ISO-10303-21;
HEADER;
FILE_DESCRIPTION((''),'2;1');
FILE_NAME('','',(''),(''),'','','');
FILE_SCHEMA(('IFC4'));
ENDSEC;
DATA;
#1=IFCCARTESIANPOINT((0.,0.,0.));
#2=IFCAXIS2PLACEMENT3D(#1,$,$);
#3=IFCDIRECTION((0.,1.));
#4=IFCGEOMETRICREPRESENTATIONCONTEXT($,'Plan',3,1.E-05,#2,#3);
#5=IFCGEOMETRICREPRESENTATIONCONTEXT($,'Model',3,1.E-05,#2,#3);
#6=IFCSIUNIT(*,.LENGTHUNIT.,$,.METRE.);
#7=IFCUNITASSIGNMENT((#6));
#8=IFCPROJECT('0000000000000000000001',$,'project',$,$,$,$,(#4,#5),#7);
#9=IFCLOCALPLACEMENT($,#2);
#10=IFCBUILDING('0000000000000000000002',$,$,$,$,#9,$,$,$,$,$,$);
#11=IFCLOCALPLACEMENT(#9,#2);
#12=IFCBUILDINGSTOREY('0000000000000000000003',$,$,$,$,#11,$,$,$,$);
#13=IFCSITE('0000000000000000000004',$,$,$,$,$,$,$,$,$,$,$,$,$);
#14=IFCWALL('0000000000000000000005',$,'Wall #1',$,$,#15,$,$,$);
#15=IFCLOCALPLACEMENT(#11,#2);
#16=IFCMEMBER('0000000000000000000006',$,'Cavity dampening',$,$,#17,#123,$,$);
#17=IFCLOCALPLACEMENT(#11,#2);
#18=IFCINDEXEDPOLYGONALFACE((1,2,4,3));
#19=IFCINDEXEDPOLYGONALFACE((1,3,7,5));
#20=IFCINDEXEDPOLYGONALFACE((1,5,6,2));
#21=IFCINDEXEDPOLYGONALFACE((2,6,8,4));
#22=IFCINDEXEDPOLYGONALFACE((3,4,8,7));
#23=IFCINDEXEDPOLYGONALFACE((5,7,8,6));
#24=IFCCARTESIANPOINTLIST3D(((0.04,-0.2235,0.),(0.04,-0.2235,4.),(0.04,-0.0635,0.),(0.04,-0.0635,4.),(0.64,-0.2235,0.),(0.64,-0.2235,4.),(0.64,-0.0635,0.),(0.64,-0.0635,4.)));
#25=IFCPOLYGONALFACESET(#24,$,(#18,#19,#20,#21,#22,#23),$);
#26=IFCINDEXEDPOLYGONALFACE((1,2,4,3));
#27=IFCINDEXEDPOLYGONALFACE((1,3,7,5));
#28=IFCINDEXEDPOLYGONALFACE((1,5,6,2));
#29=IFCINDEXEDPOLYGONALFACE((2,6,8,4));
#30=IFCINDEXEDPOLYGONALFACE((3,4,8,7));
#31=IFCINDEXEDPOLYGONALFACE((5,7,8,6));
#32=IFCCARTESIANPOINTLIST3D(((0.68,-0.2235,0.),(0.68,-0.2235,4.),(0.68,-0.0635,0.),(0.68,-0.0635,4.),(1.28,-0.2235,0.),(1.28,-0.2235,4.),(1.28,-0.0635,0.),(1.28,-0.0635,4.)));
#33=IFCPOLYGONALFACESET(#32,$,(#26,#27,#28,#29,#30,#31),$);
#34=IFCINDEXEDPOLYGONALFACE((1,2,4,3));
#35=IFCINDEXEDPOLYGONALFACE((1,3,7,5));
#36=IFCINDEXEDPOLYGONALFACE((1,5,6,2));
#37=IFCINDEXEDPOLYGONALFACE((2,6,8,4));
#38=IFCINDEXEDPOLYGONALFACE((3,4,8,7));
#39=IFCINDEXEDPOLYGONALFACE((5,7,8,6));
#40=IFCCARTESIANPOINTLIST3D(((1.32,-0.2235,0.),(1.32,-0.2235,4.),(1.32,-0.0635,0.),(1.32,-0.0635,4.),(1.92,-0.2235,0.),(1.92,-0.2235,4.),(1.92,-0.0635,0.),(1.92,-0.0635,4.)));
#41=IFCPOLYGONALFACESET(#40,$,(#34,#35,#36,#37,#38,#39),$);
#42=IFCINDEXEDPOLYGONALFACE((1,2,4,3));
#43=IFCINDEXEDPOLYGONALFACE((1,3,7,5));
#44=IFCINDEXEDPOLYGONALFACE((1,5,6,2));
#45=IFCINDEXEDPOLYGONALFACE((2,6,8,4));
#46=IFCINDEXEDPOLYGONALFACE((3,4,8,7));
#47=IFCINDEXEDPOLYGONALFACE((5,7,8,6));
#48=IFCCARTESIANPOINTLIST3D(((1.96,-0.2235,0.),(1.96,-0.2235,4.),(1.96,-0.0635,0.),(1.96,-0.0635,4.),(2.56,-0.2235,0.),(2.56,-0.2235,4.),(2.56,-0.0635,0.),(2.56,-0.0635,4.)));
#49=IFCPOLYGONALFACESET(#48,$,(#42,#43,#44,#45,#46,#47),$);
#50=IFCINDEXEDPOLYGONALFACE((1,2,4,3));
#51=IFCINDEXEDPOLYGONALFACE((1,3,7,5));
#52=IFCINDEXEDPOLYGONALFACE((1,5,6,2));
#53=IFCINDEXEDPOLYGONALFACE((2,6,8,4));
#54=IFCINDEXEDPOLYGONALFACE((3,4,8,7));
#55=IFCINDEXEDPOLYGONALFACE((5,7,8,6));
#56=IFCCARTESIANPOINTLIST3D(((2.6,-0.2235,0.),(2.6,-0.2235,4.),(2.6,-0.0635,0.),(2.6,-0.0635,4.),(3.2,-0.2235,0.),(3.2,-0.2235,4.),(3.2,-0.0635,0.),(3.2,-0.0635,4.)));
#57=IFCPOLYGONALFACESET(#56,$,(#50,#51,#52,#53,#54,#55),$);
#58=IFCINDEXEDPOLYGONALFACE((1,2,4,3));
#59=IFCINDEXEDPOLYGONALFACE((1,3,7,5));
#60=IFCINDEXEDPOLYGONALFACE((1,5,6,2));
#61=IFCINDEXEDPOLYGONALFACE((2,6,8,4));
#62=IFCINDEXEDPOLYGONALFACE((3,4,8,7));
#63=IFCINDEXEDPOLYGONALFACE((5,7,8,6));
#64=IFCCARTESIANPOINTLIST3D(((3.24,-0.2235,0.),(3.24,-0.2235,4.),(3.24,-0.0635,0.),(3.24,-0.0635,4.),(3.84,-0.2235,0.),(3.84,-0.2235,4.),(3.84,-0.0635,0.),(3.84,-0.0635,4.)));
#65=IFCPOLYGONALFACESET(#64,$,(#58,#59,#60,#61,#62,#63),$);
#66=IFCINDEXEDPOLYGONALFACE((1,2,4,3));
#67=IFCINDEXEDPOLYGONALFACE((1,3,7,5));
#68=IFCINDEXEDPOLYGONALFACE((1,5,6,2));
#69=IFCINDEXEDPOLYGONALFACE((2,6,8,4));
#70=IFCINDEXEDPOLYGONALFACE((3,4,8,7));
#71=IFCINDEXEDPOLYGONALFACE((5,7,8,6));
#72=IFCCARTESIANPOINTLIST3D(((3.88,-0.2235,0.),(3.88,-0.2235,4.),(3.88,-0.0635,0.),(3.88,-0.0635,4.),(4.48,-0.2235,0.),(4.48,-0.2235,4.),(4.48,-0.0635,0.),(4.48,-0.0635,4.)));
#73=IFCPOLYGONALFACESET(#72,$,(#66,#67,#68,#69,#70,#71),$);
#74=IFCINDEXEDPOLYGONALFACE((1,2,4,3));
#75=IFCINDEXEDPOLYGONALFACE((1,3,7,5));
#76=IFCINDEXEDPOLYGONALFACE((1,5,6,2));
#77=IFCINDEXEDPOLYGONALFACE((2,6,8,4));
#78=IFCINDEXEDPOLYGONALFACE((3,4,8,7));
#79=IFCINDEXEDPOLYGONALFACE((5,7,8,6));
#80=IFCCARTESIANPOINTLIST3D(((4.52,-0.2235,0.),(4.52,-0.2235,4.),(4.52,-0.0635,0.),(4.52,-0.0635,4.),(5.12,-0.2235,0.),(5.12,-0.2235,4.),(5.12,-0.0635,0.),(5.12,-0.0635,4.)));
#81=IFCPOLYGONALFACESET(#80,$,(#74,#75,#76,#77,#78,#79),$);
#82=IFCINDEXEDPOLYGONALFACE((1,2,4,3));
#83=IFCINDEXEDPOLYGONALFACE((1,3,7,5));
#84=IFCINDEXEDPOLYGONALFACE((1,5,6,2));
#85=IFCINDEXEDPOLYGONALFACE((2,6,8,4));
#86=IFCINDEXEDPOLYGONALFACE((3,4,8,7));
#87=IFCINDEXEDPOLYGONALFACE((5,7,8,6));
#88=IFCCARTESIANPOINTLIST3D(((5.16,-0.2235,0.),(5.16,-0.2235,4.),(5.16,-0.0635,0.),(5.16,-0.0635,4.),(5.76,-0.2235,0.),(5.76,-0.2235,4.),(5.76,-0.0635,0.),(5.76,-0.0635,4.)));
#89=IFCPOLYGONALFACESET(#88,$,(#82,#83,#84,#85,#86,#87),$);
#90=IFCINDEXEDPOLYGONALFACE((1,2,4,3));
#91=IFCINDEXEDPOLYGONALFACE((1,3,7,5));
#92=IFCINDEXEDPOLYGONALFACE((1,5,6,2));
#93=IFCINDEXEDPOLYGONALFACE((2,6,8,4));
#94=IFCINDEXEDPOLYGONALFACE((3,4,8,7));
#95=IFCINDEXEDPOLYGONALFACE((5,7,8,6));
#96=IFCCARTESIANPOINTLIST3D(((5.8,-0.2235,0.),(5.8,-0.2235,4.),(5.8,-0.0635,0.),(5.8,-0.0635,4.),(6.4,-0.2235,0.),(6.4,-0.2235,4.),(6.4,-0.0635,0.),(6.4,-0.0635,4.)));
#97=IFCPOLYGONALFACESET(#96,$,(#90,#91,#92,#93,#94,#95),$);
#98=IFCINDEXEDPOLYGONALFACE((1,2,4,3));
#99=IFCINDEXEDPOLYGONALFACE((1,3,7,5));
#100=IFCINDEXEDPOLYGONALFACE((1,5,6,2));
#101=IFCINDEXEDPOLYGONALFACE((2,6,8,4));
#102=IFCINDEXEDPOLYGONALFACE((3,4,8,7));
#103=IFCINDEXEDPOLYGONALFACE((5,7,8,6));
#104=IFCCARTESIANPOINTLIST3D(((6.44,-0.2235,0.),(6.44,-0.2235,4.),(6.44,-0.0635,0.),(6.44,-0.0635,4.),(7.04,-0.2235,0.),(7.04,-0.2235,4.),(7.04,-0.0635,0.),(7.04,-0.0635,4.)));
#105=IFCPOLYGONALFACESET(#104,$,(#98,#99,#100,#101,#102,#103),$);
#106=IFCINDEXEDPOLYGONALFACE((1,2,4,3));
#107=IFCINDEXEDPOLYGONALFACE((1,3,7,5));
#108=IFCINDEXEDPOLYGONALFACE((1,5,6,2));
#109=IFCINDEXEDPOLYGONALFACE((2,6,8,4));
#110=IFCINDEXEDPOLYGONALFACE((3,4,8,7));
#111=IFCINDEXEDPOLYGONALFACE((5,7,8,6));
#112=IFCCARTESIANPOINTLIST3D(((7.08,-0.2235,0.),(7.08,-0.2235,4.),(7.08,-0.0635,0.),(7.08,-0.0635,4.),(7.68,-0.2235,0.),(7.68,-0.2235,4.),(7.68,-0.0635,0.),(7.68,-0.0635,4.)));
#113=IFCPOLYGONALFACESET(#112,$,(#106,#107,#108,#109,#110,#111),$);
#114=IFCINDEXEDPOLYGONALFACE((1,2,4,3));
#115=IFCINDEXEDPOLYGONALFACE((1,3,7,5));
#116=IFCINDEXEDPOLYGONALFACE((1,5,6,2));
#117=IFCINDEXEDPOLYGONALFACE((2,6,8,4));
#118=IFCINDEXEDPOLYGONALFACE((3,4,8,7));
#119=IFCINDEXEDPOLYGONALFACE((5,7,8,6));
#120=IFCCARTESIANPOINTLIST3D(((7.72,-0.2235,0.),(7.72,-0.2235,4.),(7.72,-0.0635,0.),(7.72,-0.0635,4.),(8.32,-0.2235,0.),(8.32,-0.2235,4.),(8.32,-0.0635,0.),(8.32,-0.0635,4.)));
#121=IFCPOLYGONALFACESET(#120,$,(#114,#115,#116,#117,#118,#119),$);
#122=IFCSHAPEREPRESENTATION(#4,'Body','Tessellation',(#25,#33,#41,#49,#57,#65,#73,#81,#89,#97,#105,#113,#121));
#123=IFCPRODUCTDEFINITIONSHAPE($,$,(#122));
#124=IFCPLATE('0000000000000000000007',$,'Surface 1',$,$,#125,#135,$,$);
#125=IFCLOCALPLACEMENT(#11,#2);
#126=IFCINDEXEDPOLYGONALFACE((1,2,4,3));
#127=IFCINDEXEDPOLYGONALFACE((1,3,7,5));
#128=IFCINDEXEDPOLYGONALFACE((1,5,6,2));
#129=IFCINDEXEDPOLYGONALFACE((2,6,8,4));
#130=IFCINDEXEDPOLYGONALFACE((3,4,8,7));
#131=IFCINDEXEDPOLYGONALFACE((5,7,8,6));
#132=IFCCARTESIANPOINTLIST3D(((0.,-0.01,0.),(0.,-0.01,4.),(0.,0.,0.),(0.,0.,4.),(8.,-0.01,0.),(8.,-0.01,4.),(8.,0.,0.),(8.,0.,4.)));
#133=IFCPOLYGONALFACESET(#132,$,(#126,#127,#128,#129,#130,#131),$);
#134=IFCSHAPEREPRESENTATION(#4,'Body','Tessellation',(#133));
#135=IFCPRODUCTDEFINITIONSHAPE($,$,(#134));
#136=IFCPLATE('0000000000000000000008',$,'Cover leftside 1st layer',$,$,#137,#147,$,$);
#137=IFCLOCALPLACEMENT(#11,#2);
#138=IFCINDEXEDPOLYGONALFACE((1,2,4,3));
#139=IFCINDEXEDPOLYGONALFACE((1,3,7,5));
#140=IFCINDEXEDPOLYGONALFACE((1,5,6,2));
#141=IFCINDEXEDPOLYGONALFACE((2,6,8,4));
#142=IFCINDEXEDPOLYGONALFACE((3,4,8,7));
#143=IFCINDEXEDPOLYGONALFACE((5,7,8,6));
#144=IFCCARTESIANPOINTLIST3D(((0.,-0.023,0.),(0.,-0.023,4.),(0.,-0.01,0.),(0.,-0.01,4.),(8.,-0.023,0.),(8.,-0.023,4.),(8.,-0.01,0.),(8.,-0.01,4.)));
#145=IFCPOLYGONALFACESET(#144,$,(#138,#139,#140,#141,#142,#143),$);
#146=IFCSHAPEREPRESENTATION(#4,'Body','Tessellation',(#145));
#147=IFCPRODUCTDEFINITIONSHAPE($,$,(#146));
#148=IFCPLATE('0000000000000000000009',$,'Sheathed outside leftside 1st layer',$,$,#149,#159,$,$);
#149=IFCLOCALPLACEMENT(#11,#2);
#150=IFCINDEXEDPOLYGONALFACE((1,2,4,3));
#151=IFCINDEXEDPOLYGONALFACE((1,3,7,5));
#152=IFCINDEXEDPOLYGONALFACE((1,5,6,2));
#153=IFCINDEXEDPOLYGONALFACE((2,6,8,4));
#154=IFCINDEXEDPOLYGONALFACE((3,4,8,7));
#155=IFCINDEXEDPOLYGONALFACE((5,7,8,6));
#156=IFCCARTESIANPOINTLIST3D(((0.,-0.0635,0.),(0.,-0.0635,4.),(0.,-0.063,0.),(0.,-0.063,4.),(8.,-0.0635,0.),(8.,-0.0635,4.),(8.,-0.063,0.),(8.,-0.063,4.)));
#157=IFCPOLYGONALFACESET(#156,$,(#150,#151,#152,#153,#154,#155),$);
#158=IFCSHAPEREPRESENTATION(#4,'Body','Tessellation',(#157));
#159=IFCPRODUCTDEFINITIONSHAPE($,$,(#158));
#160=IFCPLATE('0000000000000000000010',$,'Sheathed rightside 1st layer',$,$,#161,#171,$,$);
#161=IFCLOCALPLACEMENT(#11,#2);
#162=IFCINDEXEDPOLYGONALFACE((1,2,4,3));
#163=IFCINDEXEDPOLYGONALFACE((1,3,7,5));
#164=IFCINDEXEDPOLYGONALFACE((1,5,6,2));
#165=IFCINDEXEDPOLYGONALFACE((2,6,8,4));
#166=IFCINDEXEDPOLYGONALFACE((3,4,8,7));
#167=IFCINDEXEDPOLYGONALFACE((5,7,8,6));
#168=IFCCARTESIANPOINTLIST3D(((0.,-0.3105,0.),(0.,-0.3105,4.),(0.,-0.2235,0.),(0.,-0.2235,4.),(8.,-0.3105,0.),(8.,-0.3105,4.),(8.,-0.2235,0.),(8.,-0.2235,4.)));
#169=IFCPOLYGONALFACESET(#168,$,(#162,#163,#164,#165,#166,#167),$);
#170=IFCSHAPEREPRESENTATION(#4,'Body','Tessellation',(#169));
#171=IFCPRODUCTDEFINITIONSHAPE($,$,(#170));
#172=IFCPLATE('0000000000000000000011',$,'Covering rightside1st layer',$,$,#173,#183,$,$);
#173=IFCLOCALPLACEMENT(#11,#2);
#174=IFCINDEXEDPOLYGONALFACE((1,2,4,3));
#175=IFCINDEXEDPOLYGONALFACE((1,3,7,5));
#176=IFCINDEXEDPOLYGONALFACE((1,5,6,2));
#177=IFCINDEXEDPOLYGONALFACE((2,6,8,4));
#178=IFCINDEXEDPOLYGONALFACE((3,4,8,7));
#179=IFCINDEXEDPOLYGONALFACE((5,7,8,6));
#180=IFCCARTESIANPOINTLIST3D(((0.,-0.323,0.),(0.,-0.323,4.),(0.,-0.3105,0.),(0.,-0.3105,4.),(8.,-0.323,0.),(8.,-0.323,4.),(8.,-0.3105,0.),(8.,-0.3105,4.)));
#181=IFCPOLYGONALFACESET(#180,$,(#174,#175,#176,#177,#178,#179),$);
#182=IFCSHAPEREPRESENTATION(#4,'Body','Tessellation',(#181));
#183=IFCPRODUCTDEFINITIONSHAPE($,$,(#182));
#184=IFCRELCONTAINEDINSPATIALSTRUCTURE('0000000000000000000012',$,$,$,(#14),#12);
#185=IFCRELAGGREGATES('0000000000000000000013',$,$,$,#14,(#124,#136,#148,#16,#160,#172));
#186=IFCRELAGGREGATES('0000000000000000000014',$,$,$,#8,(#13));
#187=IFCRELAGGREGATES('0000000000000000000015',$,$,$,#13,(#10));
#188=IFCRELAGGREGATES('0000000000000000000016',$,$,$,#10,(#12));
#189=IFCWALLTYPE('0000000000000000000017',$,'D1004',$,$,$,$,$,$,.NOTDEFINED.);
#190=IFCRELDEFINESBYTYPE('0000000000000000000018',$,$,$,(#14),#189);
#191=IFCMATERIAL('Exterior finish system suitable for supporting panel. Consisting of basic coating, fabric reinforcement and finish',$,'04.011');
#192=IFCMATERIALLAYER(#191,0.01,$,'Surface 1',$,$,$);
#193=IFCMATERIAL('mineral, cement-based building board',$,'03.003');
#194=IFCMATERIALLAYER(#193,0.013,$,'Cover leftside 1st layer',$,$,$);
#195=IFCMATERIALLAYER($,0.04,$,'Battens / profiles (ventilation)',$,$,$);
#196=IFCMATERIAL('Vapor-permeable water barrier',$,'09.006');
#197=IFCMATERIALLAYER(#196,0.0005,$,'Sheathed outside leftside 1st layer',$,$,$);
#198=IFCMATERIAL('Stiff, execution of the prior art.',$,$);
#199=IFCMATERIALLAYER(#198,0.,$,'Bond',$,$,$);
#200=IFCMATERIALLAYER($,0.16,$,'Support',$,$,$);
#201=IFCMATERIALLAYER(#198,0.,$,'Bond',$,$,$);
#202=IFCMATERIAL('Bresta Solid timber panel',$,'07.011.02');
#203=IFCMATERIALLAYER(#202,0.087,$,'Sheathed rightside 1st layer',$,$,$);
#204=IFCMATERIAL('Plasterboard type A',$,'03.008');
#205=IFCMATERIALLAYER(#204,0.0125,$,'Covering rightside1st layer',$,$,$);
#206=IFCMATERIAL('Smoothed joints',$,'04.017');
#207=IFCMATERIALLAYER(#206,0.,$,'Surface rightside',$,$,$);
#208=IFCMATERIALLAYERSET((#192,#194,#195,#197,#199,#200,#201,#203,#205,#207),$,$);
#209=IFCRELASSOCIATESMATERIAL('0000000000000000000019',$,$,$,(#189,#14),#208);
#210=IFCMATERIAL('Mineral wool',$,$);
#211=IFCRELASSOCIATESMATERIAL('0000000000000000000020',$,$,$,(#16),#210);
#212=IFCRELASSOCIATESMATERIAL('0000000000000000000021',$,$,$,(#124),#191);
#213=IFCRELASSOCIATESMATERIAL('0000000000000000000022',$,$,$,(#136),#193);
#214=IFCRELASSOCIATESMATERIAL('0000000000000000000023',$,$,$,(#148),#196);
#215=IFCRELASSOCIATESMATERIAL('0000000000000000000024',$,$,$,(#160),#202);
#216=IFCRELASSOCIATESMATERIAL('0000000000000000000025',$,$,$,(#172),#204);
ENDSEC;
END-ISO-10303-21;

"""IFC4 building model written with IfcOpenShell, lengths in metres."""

from ifc_helpers import new_model, si_unit, direction, frame, frame_2d, origin, origin_with_axes, place, context, project, spatial, rectangle, extrude, material, layer, layer_set, type_object, element, aggregate, save


model = new_model("IFC4")

# Units and contexts
plan_context = context("Plan", 3, precision=1e-05, world=origin(), true_north=direction((0.0, 1.0)))
model_context = context("Model", 3, precision=1e-05, world=origin(), true_north=direction((0.0, 1.0)))
ifc_project = project(units=[si_unit("LENGTHUNIT", "METRE")], contexts=[plan_context, model_context])

# Site, building, storey
site = spatial("IfcSite", under=ifc_project)
building_placement = place(None, origin())
building = spatial("IfcBuilding", under=site, at=building_placement)
storey_placement = place(building_placement, origin())
storey = spatial("IfcBuildingStorey", under=building, at=storey_placement)

# Wall, member, plates
ifc_material_1 = material(Name="Exterior finish system suitable for supporting panel. Consisting of basic coating, fabric reinforcement and finish", Category="04.011")
ifc_layer_1 = layer(ifc_material_1, 0.01, Name="Surface 1")
ifc_material_2 = material(Name="mineral, cement-based building board", Category="03.003")
ifc_layer_2 = layer(ifc_material_2, 0.013, Name="Cover leftside 1st layer")
ifc_layer_3 = layer(None, 0.04, Name="Battens / profiles (ventilation)")
ifc_material_3 = material(Name="Vapor-permeable water barrier", Category="09.006")
ifc_layer_4 = layer(ifc_material_3, 0.0005, Name="Sheathed outside leftside 1st layer")
ifc_material_4 = material(Name="Stiff, execution of the prior art.")
ifc_layer_5 = layer(ifc_material_4, 0.0, Name="Bond")
ifc_layer_6 = layer(None, 0.16, Name="Support")
ifc_layer_7 = layer(ifc_material_4, 0.0, Name="Bond")
ifc_material_5 = material(Name="Bresta Solid timber panel", Category="07.011.02")
ifc_layer_8 = layer(ifc_material_5, 0.087, Name="Sheathed rightside 1st layer")
ifc_material_6 = material(Name="Plasterboard type A", Category="03.008")
ifc_layer_9 = layer(ifc_material_6, 0.0125, Name="Covering rightside1st layer")
ifc_material_7 = material(Name="Smoothed joints", Category="04.017")
ifc_layer_10 = layer(ifc_material_7, 0.0, Name="Surface rightside")
ifc_layer_set = layer_set([ifc_layer_1, ifc_layer_2, ifc_layer_3, ifc_layer_4, ifc_layer_5, ifc_layer_6, ifc_layer_7, ifc_layer_8, ifc_layer_9, ifc_layer_10])
wall_type = type_object("IfcWallType", Name="D1004", PredefinedType="NOTDEFINED", material=ifc_layer_set)
wall_placement = place(None, frame((0.0, 0.0, 0.0), z_axis=(0.0, -1.0, 0.0), x_axis=(1.0, 0.0, 0.0)))
wall = element("IfcWall", 1, at=wall_placement, inside=storey, type_object=wall_type, material=ifc_layer_set, Name="Wall #1")
ifc_material_8 = material(Name="Mineral wool")
member_1_placement = place(wall_placement, origin())
member_1 = element("IfcMember", 2, at=member_1_placement, material=ifc_material_8, Name="Cavity dampening", context=plan_context, shape_type="SweptSolid", body=[
    extrude(rectangle(XDim=0.6, YDim=0.16, at=frame_2d((0.3, 0.08), x_axis=(1.0, 0.0))), frame((0.04, 4.0, 0.0635), z_axis=(0.0, -1.0, 0.0), x_axis=(1.0, 0.0, 0.0)), (0.0, 0.0, 1.0), 4.0),
    extrude(rectangle(XDim=0.6, YDim=0.16, at=frame_2d((0.3, 0.08), x_axis=(1.0, 0.0))), frame((0.68, 4.0, 0.0635), z_axis=(0.0, -1.0, 0.0), x_axis=(1.0, 0.0, 0.0)), (0.0, 0.0, 1.0), 4.0),
    extrude(rectangle(XDim=0.6, YDim=0.16, at=frame_2d((0.3, 0.08), x_axis=(1.0, 0.0))), frame((1.32, 4.0, 0.0635), z_axis=(0.0, -1.0, 0.0), x_axis=(1.0, 0.0, 0.0)), (0.0, 0.0, 1.0), 4.0),
    extrude(rectangle(XDim=0.6, YDim=0.16, at=frame_2d((0.3, 0.08), x_axis=(1.0, 0.0))), frame((1.96, 4.0, 0.0635), z_axis=(0.0, -1.0, 0.0), x_axis=(1.0, 0.0, 0.0)), (0.0, 0.0, 1.0), 4.0),
    extrude(rectangle(XDim=0.6, YDim=0.16, at=frame_2d((0.3, 0.08), x_axis=(1.0, 0.0))), frame((2.6, 4.0, 0.0635), z_axis=(0.0, -1.0, 0.0), x_axis=(1.0, 0.0, 0.0)), (0.0, 0.0, 1.0), 4.0),
    extrude(rectangle(XDim=0.6, YDim=0.16, at=frame_2d((0.3, 0.08), x_axis=(1.0, 0.0))), frame((3.24, 4.0, 0.0635), z_axis=(0.0, -1.0, 0.0), x_axis=(1.0, 0.0, 0.0)), (0.0, 0.0, 1.0), 4.0),
    extrude(rectangle(XDim=0.6, YDim=0.16, at=frame_2d((0.3, 0.08), x_axis=(1.0, 0.0))), frame((3.88, 4.0, 0.0635), z_axis=(0.0, -1.0, 0.0), x_axis=(1.0, 0.0, 0.0)), (0.0, 0.0, 1.0), 4.0),
    extrude(rectangle(XDim=0.6, YDim=0.16, at=frame_2d((0.3, 0.08), x_axis=(1.0, 0.0))), frame((4.52, 4.0, 0.0635), z_axis=(0.0, -1.0, 0.0), x_axis=(1.0, 0.0, 0.0)), (0.0, 0.0, 1.0), 4.0),
    extrude(rectangle(XDim=0.6, YDim=0.16, at=frame_2d((0.3, 0.08), x_axis=(1.0, 0.0))), frame((5.16, 4.0, 0.0635), z_axis=(0.0, -1.0, 0.0), x_axis=(1.0, 0.0, 0.0)), (0.0, 0.0, 1.0), 4.0),
    extrude(rectangle(XDim=0.6, YDim=0.16, at=frame_2d((0.3, 0.08), x_axis=(1.0, 0.0))), frame((5.8, 4.0, 0.0635), z_axis=(0.0, -1.0, 0.0), x_axis=(1.0, 0.0, 0.0)), (0.0, 0.0, 1.0), 4.0),
    extrude(rectangle(XDim=0.6, YDim=0.16, at=frame_2d((0.3, 0.08), x_axis=(1.0, 0.0))), frame((6.44, 4.0, 0.0635), z_axis=(0.0, -1.0, 0.0), x_axis=(1.0, 0.0, 0.0)), (0.0, 0.0, 1.0), 4.0),
    extrude(rectangle(XDim=0.6, YDim=0.16, at=frame_2d((0.3, 0.08), x_axis=(1.0, 0.0))), frame((7.08, 4.0, 0.0635), z_axis=(0.0, -1.0, 0.0), x_axis=(1.0, 0.0, 0.0)), (0.0, 0.0, 1.0), 4.0),
    extrude(rectangle(XDim=0.6, YDim=0.16, at=frame_2d((0.3, 0.08), x_axis=(1.0, 0.0))), frame((7.72, 4.0, 0.0635), z_axis=(0.0, -1.0, 0.0), x_axis=(1.0, 0.0, 0.0)), (0.0, 0.0, 1.0), 4.0),
])
plate_1_placement = place(wall_placement, origin())
plate_1 = element("IfcPlate", 3, at=plate_1_placement, material=ifc_material_1, Name="Surface 1", context=plan_context, shape_type="SweptSolid", body=[
    extrude(rectangle(XDim=8.0, YDim=4.0, at=frame_2d((4.0, 2.0), x_axis=(1.0, 0.0))), origin_with_axes(), (0.0, 0.0, 1.0), 0.01),
])
plate_2_placement = place(wall_placement, origin())
plate_2 = element("IfcPlate", 4, at=plate_2_placement, material=ifc_material_2, Name="Cover leftside 1st layer", context=plan_context, shape_type="SweptSolid", body=[
    extrude(rectangle(XDim=8.0, YDim=4.0, at=frame_2d((4.0, 2.0), x_axis=(1.0, 0.0))), frame((0.0, 0.0, 0.01), z_axis=(0.0, 0.0, 1.0), x_axis=(1.0, 0.0, 0.0)), (0.0, 0.0, 1.0), 0.013),
])
plate_3_placement = place(wall_placement, origin())
plate_3 = element("IfcPlate", 5, at=plate_3_placement, material=ifc_material_3, Name="Sheathed outside leftside 1st layer", context=plan_context, shape_type="SweptSolid", body=[
    extrude(rectangle(XDim=8.0, YDim=4.0, at=frame_2d((4.0, 2.0), x_axis=(1.0, 0.0))), frame((0.0, 0.0, 0.063), z_axis=(0.0, 0.0, 1.0), x_axis=(1.0, 0.0, 0.0)), (0.0, 0.0, 1.0), 0.0005),
])
plate_4_placement = place(wall_placement, origin())
plate_4 = element("IfcPlate", 6, at=plate_4_placement, material=ifc_material_5, Name="Sheathed rightside 1st layer", context=plan_context, shape_type="SweptSolid", body=[
    extrude(rectangle(XDim=8.0, YDim=4.0, at=frame_2d((4.0, 2.0), x_axis=(1.0, 0.0))), frame((0.0, 0.0, 0.2235), z_axis=(0.0, 0.0, 1.0), x_axis=(1.0, 0.0, 0.0)), (0.0, 0.0, 1.0), 0.087),
])
plate_5_placement = place(wall_placement, origin())
plate_5 = element("IfcPlate", 7, at=plate_5_placement, material=ifc_material_6, Name="Covering rightside1st layer", context=plan_context, shape_type="SweptSolid", body=[
    extrude(rectangle(XDim=8.0, YDim=4.0, at=frame_2d((4.0, 2.0), x_axis=(1.0, 0.0))), frame((0.0, 0.0, 0.3105), z_axis=(0.0, 0.0, 1.0), x_axis=(1.0, 0.0, 0.0)), (0.0, 0.0, 1.0), 0.0125),
])
aggregate(wall, [plate_1, plate_2, plate_3, member_1, plate_4, plate_5])

save(model, "model.ifc")
